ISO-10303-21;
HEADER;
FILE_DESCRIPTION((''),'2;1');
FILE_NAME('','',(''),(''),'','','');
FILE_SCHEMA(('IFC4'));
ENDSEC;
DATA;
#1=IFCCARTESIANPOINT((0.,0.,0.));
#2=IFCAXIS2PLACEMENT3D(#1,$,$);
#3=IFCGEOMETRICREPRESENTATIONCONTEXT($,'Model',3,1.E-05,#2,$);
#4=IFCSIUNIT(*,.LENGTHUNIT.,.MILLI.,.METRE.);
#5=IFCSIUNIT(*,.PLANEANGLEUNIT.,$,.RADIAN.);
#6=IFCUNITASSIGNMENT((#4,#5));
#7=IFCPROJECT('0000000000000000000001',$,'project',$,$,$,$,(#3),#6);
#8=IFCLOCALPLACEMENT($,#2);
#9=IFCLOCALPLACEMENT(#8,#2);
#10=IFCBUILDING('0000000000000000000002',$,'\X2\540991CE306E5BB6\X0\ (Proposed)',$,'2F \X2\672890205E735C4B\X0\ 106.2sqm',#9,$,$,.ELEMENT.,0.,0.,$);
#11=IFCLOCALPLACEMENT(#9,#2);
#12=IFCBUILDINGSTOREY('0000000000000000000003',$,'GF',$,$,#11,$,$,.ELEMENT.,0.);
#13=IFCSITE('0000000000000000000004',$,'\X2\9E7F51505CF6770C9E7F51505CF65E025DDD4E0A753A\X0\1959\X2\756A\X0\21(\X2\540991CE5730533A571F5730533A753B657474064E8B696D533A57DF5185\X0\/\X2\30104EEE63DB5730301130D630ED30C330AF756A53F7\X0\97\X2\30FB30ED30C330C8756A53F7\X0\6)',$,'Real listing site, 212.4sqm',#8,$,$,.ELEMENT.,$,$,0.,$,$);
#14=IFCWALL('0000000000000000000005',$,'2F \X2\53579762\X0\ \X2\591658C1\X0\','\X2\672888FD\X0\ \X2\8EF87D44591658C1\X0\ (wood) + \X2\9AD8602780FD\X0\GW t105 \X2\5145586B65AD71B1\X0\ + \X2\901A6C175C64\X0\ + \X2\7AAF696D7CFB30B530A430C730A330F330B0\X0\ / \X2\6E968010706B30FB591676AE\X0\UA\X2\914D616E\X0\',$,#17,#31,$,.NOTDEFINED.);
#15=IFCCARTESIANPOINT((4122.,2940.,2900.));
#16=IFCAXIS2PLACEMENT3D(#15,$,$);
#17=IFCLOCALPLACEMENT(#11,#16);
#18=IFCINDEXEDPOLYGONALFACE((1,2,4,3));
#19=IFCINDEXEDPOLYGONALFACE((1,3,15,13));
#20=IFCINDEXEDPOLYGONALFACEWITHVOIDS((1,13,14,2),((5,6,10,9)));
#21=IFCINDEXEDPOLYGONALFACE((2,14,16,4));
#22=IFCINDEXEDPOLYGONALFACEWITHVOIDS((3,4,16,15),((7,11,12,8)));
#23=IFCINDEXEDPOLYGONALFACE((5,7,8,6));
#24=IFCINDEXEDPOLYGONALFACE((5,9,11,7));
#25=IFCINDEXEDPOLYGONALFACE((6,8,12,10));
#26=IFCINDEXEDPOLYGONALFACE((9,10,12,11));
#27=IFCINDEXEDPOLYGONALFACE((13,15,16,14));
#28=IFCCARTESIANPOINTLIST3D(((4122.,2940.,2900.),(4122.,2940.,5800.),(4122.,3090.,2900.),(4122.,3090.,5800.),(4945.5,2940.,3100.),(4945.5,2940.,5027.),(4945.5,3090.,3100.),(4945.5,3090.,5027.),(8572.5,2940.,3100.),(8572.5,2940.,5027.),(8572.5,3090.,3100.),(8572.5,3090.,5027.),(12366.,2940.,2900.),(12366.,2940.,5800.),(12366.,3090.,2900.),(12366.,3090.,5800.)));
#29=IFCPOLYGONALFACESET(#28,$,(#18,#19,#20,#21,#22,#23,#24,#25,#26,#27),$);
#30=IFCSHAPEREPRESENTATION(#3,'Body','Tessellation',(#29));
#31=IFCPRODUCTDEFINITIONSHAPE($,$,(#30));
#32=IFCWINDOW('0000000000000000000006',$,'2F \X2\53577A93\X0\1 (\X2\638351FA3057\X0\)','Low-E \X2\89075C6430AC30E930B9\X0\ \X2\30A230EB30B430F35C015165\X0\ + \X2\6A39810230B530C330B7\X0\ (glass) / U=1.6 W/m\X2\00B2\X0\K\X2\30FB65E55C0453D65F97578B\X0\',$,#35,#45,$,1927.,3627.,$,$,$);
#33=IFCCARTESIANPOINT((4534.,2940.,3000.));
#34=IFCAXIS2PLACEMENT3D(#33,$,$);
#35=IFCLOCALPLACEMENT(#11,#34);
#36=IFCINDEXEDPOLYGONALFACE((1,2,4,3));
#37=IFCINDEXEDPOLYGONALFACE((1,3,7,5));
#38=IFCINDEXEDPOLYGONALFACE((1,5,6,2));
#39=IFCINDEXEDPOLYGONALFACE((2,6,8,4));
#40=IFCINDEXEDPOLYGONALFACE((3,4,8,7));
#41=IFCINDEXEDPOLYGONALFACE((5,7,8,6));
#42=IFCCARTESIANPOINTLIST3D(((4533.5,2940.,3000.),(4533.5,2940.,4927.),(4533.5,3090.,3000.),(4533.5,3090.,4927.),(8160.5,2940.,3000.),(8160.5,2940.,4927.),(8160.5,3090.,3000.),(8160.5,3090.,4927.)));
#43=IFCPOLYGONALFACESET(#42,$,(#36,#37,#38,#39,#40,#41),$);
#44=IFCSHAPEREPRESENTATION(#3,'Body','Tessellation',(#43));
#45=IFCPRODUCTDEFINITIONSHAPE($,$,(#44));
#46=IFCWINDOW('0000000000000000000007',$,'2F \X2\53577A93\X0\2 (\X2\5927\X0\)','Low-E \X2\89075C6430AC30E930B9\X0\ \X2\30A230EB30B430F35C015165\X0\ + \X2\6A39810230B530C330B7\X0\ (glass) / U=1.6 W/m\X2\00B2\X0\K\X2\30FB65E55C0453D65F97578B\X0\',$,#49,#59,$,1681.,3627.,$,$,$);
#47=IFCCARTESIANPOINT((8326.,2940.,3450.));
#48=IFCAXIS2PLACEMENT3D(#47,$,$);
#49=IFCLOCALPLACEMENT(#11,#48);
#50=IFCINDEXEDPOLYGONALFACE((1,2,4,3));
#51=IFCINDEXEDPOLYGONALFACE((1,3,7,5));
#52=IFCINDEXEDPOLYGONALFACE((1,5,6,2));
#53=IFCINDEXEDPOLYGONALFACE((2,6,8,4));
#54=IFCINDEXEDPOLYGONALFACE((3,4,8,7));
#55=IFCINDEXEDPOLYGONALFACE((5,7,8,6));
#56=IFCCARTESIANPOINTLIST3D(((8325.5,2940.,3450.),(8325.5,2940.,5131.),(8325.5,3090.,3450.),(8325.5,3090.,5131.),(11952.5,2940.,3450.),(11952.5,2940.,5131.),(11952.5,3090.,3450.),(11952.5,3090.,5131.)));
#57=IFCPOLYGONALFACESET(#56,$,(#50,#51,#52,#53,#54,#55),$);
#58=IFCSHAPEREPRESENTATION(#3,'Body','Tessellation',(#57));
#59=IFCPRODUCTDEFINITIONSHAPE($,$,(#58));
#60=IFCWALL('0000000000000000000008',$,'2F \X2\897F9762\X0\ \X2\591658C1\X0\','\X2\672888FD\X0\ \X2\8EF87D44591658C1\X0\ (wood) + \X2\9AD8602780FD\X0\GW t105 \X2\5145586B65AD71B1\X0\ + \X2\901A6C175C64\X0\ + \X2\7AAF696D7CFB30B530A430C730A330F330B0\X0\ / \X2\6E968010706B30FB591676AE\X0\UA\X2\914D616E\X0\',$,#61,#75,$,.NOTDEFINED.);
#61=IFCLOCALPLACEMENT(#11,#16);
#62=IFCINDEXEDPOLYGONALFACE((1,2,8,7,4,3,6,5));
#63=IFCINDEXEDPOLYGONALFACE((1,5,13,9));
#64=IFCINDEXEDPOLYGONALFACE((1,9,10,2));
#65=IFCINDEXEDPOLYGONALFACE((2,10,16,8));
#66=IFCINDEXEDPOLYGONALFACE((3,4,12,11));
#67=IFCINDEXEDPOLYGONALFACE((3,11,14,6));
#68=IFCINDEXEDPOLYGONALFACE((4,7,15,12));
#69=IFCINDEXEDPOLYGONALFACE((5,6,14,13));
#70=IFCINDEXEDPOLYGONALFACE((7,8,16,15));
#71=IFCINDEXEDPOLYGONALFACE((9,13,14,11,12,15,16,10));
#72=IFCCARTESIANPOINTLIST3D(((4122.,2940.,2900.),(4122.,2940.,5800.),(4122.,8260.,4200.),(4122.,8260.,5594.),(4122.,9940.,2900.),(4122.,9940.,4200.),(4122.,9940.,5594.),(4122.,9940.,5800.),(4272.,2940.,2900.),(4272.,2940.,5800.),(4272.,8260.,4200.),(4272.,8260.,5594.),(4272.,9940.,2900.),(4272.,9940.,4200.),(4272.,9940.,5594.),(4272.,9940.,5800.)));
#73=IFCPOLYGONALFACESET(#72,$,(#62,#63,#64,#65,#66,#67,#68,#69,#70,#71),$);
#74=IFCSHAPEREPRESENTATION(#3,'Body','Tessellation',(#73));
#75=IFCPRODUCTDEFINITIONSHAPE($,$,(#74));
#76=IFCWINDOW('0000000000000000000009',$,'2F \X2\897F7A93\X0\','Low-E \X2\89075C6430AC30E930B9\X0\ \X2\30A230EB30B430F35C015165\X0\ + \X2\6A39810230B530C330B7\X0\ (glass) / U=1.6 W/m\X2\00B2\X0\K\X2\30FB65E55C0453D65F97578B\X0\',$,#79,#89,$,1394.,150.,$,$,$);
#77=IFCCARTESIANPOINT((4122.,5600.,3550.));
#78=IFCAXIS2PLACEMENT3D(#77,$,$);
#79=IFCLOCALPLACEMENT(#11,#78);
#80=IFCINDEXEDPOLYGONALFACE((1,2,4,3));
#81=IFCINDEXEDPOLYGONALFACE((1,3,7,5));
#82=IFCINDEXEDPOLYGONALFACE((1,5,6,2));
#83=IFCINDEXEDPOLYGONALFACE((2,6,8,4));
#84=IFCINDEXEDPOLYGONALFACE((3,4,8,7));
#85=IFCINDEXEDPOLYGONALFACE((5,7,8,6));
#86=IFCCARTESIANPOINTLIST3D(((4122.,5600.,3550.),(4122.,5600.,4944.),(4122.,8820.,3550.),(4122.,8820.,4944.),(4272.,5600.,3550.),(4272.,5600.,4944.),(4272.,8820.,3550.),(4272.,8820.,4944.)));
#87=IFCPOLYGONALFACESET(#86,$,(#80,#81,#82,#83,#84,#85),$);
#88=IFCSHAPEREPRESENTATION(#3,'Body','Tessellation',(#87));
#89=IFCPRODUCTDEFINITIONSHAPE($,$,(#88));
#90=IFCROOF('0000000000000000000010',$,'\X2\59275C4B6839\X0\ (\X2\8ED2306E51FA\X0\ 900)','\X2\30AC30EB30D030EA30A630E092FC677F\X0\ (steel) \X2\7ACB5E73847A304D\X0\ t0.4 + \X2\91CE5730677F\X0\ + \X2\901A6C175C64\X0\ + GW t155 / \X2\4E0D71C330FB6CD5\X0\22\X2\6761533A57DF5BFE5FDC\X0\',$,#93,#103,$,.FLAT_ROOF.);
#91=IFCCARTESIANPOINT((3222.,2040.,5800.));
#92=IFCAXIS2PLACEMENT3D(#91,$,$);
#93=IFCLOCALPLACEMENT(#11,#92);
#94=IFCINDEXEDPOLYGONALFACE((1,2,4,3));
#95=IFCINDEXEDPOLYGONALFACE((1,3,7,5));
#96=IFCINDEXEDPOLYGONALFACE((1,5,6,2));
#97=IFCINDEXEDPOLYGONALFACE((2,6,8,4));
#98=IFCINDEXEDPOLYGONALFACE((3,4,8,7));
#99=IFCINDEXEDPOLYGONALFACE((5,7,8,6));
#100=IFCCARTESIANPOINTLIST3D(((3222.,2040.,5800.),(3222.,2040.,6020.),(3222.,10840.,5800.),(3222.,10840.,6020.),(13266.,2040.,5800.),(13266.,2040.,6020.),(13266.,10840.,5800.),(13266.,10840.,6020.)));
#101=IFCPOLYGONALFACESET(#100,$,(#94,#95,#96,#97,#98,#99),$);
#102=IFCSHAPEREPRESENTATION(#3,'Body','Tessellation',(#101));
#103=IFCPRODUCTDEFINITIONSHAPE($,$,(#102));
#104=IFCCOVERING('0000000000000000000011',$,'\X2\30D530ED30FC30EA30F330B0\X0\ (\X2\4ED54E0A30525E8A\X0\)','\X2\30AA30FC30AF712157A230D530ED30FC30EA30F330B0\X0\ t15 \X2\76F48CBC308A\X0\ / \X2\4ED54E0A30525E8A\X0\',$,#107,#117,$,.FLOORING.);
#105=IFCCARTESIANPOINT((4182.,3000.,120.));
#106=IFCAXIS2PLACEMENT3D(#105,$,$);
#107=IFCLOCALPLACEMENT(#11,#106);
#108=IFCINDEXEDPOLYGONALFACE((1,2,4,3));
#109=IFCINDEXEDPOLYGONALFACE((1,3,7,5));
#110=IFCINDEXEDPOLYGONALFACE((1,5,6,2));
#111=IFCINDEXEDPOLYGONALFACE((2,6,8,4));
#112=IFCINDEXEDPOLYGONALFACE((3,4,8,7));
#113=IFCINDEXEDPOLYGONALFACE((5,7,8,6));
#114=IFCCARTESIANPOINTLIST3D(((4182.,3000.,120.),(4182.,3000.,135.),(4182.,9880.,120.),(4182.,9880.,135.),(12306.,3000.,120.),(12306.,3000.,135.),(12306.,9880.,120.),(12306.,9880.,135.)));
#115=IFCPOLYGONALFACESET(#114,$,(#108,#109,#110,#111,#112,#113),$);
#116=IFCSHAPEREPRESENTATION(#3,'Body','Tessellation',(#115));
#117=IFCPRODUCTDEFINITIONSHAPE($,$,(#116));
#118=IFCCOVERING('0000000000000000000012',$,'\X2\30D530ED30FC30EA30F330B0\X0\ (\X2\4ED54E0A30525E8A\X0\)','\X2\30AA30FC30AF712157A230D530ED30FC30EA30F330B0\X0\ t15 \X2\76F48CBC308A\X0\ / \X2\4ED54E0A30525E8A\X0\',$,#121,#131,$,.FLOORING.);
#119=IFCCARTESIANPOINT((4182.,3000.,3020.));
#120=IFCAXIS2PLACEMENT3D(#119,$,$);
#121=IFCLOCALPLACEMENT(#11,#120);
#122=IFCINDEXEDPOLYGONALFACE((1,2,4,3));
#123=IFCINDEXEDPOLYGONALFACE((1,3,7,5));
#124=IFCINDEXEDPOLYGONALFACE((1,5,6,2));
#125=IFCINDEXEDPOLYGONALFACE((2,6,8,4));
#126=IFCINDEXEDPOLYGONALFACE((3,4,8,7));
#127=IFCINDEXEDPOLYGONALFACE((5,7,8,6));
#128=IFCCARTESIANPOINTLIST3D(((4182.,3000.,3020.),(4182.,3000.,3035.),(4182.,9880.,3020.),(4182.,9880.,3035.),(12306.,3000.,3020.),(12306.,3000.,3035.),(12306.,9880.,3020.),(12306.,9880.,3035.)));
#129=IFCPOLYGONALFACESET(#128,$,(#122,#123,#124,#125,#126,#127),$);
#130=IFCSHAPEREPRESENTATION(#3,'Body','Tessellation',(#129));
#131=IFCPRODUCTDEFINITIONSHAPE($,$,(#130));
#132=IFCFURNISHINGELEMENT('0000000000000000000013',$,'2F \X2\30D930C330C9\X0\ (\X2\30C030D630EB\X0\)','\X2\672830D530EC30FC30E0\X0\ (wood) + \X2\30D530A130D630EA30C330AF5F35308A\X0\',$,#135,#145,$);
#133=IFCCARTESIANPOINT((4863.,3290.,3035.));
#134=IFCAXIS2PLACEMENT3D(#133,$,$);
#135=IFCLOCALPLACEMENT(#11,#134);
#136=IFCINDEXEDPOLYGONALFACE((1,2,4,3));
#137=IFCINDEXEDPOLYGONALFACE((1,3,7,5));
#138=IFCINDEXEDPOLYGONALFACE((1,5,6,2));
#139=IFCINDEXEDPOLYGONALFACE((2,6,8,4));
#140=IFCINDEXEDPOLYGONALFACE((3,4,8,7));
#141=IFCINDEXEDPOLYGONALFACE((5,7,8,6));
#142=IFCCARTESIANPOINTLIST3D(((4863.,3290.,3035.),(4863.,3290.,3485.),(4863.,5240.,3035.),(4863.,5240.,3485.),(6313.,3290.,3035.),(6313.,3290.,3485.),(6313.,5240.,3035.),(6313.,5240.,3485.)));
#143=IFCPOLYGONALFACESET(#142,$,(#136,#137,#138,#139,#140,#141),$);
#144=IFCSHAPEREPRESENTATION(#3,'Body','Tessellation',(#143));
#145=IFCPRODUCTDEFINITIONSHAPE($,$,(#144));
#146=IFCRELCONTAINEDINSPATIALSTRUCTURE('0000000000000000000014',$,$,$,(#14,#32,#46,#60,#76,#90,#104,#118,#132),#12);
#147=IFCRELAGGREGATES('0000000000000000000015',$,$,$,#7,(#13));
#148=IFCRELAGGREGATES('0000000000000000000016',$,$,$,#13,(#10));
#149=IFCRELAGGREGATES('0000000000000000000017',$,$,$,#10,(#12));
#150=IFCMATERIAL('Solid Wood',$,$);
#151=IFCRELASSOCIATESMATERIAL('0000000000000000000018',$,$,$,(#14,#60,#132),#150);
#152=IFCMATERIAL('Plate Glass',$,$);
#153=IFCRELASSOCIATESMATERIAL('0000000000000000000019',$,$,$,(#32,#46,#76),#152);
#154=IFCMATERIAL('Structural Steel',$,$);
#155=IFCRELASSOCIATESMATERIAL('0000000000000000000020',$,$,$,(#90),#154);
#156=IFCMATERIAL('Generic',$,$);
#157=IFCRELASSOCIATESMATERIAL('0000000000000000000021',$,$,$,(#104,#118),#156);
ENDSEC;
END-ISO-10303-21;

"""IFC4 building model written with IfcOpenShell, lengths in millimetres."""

from ifc_helpers import new_model, si_unit, frame, frame_2d, origin, place, context, project, spatial, rectangle, extrude, material, element, fill, save


model = new_model("IFC4")

# Units and contexts
model_context = context("Model", 3, precision=1e-05, world=origin())
ifc_project = project(units=[si_unit("LENGTHUNIT", "METRE", prefix="MILLI"), si_unit("PLANEANGLEUNIT", "RADIAN")], contexts=[model_context])

# Site, building, storey
site_placement = place(None, origin())
site = spatial("IfcSite", under=ifc_project, at=site_placement, Name="鹿児島県鹿児島市川上町1959番21(吉野地区土地区画整理事業区域内/【仮換地】ブロック番号97・ロット番号6)", ObjectType="Real listing site, 212.4sqm", CompositionType="ELEMENT", RefElevation=0.0)
building_placement = place(site_placement, origin())
building = spatial("IfcBuilding", under=site, at=building_placement, Name="吉野の家 (Proposed)", ObjectType="2F 木造平屋 106.2sqm", CompositionType="ELEMENT", ElevationOfRefHeight=0.0, ElevationOfTerrain=0.0)
storey_placement = place(building_placement, origin())
storey = spatial("IfcBuildingStorey", under=building, at=storey_placement, Name="GF", CompositionType="ELEMENT", Elevation=0.0)

# Shared definitions
ifc_material_1 = material(Name="Solid Wood")

# Shared definitions
ifc_material_2 = material(Name="Plate Glass")

# Wall, openings, windows
wall_1_placement = place(storey_placement, frame((4122.0, 2940.0, 2900.0)))
wall_1 = element("IfcWall", 1, at=wall_1_placement, inside=storey, material=ifc_material_1, Name="2F 南面 外壁", Description="木製 軸組外壁 (wood) + 高性能GW t105 充填断熱 + 通気層 + 窯業系サイディング / 準耐火・外皮UA配慮", PredefinedType="NOTDEFINED", context=model_context, shape_type="SweptSolid", body=[
    extrude(rectangle(XDim=8244.0, YDim=150.0, at=frame_2d((4122.0, 75.0))), frame((4122.0, 2940.0, 2900.0)), (0.0, 0.0, 1.0), 2900.0),
])
opening_1_placement = place(storey_placement, frame((4534.0, 2940.0, 3000.0)))
opening_1 = element("IfcOpeningElement", 2, at=opening_1_placement, cuts=wall_1, PredefinedType="NOTDEFINED", context=model_context, shape_type="SweptSolid", body=[
    extrude(rectangle(XDim=3627.0, YDim=150.0, at=frame_2d((1813.0, 75.0))), frame((4534.0, 2940.0, 3000.0)), (0.0, 0.0, 1.0), 1927.0),
])
opening_2_placement = place(storey_placement, frame((8326.0, 2940.0, 3450.0)))
opening_2 = element("IfcOpeningElement", 3, at=opening_2_placement, cuts=wall_1, PredefinedType="NOTDEFINED", context=model_context, shape_type="SweptSolid", body=[
    extrude(rectangle(XDim=3627.0, YDim=150.0, at=frame_2d((1813.0, 75.0))), frame((8326.0, 2940.0, 3450.0)), (0.0, 0.0, 1.0), 1681.0),
])
window_1_placement = place(storey_placement, frame((4534.0, 2940.0, 3000.0)))
window_1 = element("IfcWindow", 4, at=window_1_placement, inside=storey, material=ifc_material_2, Name="2F 南窓1 (掃出し)", Description="Low-E 複層ガラス アルゴン封入 + 樹脂サッシ (glass) / U=1.6 W/m²K・日射取得型", OverallHeight=1927.0, OverallWidth=3627.0, context=model_context, shape_type="SweptSolid", body=[
    extrude(rectangle(XDim=3627.0, YDim=150.0, at=frame_2d((1813.0, 75.0))), frame((4534.0, 2940.0, 3000.0)), (0.0, 0.0, 1.0), 1927.0),
])
fill(opening_1, window_1)
window_2_placement = place(storey_placement, frame((8326.0, 2940.0, 3450.0)))
window_2 = element("IfcWindow", 5, at=window_2_placement, inside=storey, material=ifc_material_2, Name="2F 南窓2 (大)", Description="Low-E 複層ガラス アルゴン封入 + 樹脂サッシ (glass) / U=1.6 W/m²K・日射取得型", OverallHeight=1681.0, OverallWidth=3627.0, context=model_context, shape_type="SweptSolid", body=[
    extrude(rectangle(XDim=3627.0, YDim=150.0, at=frame_2d((1813.0, 75.0))), frame((8326.0, 2940.0, 3450.0)), (0.0, 0.0, 1.0), 1681.0),
])
fill(opening_2, window_2)

# Wall, opening, window
wall_2_placement = place(storey_placement, frame((4122.0, 2940.0, 2900.0)))
wall_2 = element("IfcWall", 6, at=wall_2_placement, inside=storey, material=ifc_material_1, Name="2F 西面 外壁", Description="木製 軸組外壁 (wood) + 高性能GW t105 充填断熱 + 通気層 + 窯業系サイディング / 準耐火・外皮UA配慮", PredefinedType="NOTDEFINED", context=model_context, shape_type="SweptSolid", body=[
    extrude(rectangle(XDim=150.0, YDim=7000.0, at=frame_2d((75.0, 3500.0))), frame((4122.0, 2940.0, 2900.0)), (0.0, 0.0, 1.0), 2900.0),
])
opening_3_placement = place(storey_placement, frame((4122.0, 5600.0, 3550.0)))
opening_3 = element("IfcOpeningElement", 7, at=opening_3_placement, cuts=wall_2, PredefinedType="NOTDEFINED", context=model_context, shape_type="SweptSolid", body=[
    extrude(rectangle(XDim=150.0, YDim=3220.0, at=frame_2d((75.0, 1610.0))), frame((4122.0, 5600.0, 3550.0)), (0.0, 0.0, 1.0), 1394.0),
])
window_3_placement = place(storey_placement, frame((4122.0, 5600.0, 3550.0)))
window_3 = element("IfcWindow", 8, at=window_3_placement, inside=storey, material=ifc_material_2, Name="2F 西窓", Description="Low-E 複層ガラス アルゴン封入 + 樹脂サッシ (glass) / U=1.6 W/m²K・日射取得型", OverallHeight=1394.0, OverallWidth=150.0, context=model_context, shape_type="SweptSolid", body=[
    extrude(rectangle(XDim=150.0, YDim=3220.0, at=frame_2d((75.0, 1610.0))), frame((4122.0, 5600.0, 3550.0)), (0.0, 0.0, 1.0), 1394.0),
])
fill(opening_3, window_3)

# Roof
ifc_material_3 = material(Name="Structural Steel")
roof_placement = place(storey_placement, frame((3222.0, 2040.0, 5800.0)))
element("IfcRoof", 9, at=roof_placement, inside=storey, material=ifc_material_3, Name="大屋根 (軒の出 900)", Description="ガルバリウム鋼板 (steel) 立平葺き t0.4 + 野地板 + 通気層 + GW t155 / 不燃・法22条区域対応", PredefinedType="FLAT_ROOF", context=model_context, shape_type="SweptSolid", body=[
    extrude(rectangle(XDim=10044.0, YDim=8800.0, at=frame_2d((5022.0, 4400.0))), frame((3222.0, 2040.0, 5800.0)), (0.0, 0.0, 1.0), 220.0),
])

# Coverings
ifc_material_4 = material(Name="Generic")
covering_1_placement = place(storey_placement, frame((4182.0, 3000.0, 120.0)))
element("IfcCovering", 10, at=covering_1_placement, inside=storey, material=ifc_material_4, Name="フローリング (仕上げ床)", Description="オーク無垢フローリング t15 直貼り / 仕上げ床", PredefinedType="FLOORING", context=model_context, shape_type="SweptSolid", body=[
    extrude(rectangle(XDim=8124.0, YDim=6880.0, at=frame_2d((4062.0, 3440.0))), frame((4182.0, 3000.0, 120.0)), (0.0, 0.0, 1.0), 15.0),
])
covering_2_placement = place(storey_placement, frame((4182.0, 3000.0, 3020.0)))
element("IfcCovering", 11, at=covering_2_placement, inside=storey, material=ifc_material_4, Name="フローリング (仕上げ床)", Description="オーク無垢フローリング t15 直貼り / 仕上げ床", PredefinedType="FLOORING", context=model_context, shape_type="SweptSolid", body=[
    extrude(rectangle(XDim=8124.0, YDim=6880.0, at=frame_2d((4062.0, 3440.0))), frame((4182.0, 3000.0, 3020.0)), (0.0, 0.0, 1.0), 15.0),
])

# Furnishing element
furnishing_placement = place(storey_placement, frame((4863.0, 3290.0, 3035.0)))
element("IfcFurnishingElement", 12, at=furnishing_placement, inside=storey, material=ifc_material_1, Name="2F ベッド (ダブル)", Description="木フレーム (wood) + ファブリック張り", context=model_context, shape_type="SweptSolid", body=[
    extrude(rectangle(XDim=1450.0, YDim=1950.0, at=frame_2d((725.0, 975.0))), frame((4863.0, 3290.0, 3035.0)), (0.0, 0.0, 1.0), 450.0),
])

save(model, "model.ifc")
